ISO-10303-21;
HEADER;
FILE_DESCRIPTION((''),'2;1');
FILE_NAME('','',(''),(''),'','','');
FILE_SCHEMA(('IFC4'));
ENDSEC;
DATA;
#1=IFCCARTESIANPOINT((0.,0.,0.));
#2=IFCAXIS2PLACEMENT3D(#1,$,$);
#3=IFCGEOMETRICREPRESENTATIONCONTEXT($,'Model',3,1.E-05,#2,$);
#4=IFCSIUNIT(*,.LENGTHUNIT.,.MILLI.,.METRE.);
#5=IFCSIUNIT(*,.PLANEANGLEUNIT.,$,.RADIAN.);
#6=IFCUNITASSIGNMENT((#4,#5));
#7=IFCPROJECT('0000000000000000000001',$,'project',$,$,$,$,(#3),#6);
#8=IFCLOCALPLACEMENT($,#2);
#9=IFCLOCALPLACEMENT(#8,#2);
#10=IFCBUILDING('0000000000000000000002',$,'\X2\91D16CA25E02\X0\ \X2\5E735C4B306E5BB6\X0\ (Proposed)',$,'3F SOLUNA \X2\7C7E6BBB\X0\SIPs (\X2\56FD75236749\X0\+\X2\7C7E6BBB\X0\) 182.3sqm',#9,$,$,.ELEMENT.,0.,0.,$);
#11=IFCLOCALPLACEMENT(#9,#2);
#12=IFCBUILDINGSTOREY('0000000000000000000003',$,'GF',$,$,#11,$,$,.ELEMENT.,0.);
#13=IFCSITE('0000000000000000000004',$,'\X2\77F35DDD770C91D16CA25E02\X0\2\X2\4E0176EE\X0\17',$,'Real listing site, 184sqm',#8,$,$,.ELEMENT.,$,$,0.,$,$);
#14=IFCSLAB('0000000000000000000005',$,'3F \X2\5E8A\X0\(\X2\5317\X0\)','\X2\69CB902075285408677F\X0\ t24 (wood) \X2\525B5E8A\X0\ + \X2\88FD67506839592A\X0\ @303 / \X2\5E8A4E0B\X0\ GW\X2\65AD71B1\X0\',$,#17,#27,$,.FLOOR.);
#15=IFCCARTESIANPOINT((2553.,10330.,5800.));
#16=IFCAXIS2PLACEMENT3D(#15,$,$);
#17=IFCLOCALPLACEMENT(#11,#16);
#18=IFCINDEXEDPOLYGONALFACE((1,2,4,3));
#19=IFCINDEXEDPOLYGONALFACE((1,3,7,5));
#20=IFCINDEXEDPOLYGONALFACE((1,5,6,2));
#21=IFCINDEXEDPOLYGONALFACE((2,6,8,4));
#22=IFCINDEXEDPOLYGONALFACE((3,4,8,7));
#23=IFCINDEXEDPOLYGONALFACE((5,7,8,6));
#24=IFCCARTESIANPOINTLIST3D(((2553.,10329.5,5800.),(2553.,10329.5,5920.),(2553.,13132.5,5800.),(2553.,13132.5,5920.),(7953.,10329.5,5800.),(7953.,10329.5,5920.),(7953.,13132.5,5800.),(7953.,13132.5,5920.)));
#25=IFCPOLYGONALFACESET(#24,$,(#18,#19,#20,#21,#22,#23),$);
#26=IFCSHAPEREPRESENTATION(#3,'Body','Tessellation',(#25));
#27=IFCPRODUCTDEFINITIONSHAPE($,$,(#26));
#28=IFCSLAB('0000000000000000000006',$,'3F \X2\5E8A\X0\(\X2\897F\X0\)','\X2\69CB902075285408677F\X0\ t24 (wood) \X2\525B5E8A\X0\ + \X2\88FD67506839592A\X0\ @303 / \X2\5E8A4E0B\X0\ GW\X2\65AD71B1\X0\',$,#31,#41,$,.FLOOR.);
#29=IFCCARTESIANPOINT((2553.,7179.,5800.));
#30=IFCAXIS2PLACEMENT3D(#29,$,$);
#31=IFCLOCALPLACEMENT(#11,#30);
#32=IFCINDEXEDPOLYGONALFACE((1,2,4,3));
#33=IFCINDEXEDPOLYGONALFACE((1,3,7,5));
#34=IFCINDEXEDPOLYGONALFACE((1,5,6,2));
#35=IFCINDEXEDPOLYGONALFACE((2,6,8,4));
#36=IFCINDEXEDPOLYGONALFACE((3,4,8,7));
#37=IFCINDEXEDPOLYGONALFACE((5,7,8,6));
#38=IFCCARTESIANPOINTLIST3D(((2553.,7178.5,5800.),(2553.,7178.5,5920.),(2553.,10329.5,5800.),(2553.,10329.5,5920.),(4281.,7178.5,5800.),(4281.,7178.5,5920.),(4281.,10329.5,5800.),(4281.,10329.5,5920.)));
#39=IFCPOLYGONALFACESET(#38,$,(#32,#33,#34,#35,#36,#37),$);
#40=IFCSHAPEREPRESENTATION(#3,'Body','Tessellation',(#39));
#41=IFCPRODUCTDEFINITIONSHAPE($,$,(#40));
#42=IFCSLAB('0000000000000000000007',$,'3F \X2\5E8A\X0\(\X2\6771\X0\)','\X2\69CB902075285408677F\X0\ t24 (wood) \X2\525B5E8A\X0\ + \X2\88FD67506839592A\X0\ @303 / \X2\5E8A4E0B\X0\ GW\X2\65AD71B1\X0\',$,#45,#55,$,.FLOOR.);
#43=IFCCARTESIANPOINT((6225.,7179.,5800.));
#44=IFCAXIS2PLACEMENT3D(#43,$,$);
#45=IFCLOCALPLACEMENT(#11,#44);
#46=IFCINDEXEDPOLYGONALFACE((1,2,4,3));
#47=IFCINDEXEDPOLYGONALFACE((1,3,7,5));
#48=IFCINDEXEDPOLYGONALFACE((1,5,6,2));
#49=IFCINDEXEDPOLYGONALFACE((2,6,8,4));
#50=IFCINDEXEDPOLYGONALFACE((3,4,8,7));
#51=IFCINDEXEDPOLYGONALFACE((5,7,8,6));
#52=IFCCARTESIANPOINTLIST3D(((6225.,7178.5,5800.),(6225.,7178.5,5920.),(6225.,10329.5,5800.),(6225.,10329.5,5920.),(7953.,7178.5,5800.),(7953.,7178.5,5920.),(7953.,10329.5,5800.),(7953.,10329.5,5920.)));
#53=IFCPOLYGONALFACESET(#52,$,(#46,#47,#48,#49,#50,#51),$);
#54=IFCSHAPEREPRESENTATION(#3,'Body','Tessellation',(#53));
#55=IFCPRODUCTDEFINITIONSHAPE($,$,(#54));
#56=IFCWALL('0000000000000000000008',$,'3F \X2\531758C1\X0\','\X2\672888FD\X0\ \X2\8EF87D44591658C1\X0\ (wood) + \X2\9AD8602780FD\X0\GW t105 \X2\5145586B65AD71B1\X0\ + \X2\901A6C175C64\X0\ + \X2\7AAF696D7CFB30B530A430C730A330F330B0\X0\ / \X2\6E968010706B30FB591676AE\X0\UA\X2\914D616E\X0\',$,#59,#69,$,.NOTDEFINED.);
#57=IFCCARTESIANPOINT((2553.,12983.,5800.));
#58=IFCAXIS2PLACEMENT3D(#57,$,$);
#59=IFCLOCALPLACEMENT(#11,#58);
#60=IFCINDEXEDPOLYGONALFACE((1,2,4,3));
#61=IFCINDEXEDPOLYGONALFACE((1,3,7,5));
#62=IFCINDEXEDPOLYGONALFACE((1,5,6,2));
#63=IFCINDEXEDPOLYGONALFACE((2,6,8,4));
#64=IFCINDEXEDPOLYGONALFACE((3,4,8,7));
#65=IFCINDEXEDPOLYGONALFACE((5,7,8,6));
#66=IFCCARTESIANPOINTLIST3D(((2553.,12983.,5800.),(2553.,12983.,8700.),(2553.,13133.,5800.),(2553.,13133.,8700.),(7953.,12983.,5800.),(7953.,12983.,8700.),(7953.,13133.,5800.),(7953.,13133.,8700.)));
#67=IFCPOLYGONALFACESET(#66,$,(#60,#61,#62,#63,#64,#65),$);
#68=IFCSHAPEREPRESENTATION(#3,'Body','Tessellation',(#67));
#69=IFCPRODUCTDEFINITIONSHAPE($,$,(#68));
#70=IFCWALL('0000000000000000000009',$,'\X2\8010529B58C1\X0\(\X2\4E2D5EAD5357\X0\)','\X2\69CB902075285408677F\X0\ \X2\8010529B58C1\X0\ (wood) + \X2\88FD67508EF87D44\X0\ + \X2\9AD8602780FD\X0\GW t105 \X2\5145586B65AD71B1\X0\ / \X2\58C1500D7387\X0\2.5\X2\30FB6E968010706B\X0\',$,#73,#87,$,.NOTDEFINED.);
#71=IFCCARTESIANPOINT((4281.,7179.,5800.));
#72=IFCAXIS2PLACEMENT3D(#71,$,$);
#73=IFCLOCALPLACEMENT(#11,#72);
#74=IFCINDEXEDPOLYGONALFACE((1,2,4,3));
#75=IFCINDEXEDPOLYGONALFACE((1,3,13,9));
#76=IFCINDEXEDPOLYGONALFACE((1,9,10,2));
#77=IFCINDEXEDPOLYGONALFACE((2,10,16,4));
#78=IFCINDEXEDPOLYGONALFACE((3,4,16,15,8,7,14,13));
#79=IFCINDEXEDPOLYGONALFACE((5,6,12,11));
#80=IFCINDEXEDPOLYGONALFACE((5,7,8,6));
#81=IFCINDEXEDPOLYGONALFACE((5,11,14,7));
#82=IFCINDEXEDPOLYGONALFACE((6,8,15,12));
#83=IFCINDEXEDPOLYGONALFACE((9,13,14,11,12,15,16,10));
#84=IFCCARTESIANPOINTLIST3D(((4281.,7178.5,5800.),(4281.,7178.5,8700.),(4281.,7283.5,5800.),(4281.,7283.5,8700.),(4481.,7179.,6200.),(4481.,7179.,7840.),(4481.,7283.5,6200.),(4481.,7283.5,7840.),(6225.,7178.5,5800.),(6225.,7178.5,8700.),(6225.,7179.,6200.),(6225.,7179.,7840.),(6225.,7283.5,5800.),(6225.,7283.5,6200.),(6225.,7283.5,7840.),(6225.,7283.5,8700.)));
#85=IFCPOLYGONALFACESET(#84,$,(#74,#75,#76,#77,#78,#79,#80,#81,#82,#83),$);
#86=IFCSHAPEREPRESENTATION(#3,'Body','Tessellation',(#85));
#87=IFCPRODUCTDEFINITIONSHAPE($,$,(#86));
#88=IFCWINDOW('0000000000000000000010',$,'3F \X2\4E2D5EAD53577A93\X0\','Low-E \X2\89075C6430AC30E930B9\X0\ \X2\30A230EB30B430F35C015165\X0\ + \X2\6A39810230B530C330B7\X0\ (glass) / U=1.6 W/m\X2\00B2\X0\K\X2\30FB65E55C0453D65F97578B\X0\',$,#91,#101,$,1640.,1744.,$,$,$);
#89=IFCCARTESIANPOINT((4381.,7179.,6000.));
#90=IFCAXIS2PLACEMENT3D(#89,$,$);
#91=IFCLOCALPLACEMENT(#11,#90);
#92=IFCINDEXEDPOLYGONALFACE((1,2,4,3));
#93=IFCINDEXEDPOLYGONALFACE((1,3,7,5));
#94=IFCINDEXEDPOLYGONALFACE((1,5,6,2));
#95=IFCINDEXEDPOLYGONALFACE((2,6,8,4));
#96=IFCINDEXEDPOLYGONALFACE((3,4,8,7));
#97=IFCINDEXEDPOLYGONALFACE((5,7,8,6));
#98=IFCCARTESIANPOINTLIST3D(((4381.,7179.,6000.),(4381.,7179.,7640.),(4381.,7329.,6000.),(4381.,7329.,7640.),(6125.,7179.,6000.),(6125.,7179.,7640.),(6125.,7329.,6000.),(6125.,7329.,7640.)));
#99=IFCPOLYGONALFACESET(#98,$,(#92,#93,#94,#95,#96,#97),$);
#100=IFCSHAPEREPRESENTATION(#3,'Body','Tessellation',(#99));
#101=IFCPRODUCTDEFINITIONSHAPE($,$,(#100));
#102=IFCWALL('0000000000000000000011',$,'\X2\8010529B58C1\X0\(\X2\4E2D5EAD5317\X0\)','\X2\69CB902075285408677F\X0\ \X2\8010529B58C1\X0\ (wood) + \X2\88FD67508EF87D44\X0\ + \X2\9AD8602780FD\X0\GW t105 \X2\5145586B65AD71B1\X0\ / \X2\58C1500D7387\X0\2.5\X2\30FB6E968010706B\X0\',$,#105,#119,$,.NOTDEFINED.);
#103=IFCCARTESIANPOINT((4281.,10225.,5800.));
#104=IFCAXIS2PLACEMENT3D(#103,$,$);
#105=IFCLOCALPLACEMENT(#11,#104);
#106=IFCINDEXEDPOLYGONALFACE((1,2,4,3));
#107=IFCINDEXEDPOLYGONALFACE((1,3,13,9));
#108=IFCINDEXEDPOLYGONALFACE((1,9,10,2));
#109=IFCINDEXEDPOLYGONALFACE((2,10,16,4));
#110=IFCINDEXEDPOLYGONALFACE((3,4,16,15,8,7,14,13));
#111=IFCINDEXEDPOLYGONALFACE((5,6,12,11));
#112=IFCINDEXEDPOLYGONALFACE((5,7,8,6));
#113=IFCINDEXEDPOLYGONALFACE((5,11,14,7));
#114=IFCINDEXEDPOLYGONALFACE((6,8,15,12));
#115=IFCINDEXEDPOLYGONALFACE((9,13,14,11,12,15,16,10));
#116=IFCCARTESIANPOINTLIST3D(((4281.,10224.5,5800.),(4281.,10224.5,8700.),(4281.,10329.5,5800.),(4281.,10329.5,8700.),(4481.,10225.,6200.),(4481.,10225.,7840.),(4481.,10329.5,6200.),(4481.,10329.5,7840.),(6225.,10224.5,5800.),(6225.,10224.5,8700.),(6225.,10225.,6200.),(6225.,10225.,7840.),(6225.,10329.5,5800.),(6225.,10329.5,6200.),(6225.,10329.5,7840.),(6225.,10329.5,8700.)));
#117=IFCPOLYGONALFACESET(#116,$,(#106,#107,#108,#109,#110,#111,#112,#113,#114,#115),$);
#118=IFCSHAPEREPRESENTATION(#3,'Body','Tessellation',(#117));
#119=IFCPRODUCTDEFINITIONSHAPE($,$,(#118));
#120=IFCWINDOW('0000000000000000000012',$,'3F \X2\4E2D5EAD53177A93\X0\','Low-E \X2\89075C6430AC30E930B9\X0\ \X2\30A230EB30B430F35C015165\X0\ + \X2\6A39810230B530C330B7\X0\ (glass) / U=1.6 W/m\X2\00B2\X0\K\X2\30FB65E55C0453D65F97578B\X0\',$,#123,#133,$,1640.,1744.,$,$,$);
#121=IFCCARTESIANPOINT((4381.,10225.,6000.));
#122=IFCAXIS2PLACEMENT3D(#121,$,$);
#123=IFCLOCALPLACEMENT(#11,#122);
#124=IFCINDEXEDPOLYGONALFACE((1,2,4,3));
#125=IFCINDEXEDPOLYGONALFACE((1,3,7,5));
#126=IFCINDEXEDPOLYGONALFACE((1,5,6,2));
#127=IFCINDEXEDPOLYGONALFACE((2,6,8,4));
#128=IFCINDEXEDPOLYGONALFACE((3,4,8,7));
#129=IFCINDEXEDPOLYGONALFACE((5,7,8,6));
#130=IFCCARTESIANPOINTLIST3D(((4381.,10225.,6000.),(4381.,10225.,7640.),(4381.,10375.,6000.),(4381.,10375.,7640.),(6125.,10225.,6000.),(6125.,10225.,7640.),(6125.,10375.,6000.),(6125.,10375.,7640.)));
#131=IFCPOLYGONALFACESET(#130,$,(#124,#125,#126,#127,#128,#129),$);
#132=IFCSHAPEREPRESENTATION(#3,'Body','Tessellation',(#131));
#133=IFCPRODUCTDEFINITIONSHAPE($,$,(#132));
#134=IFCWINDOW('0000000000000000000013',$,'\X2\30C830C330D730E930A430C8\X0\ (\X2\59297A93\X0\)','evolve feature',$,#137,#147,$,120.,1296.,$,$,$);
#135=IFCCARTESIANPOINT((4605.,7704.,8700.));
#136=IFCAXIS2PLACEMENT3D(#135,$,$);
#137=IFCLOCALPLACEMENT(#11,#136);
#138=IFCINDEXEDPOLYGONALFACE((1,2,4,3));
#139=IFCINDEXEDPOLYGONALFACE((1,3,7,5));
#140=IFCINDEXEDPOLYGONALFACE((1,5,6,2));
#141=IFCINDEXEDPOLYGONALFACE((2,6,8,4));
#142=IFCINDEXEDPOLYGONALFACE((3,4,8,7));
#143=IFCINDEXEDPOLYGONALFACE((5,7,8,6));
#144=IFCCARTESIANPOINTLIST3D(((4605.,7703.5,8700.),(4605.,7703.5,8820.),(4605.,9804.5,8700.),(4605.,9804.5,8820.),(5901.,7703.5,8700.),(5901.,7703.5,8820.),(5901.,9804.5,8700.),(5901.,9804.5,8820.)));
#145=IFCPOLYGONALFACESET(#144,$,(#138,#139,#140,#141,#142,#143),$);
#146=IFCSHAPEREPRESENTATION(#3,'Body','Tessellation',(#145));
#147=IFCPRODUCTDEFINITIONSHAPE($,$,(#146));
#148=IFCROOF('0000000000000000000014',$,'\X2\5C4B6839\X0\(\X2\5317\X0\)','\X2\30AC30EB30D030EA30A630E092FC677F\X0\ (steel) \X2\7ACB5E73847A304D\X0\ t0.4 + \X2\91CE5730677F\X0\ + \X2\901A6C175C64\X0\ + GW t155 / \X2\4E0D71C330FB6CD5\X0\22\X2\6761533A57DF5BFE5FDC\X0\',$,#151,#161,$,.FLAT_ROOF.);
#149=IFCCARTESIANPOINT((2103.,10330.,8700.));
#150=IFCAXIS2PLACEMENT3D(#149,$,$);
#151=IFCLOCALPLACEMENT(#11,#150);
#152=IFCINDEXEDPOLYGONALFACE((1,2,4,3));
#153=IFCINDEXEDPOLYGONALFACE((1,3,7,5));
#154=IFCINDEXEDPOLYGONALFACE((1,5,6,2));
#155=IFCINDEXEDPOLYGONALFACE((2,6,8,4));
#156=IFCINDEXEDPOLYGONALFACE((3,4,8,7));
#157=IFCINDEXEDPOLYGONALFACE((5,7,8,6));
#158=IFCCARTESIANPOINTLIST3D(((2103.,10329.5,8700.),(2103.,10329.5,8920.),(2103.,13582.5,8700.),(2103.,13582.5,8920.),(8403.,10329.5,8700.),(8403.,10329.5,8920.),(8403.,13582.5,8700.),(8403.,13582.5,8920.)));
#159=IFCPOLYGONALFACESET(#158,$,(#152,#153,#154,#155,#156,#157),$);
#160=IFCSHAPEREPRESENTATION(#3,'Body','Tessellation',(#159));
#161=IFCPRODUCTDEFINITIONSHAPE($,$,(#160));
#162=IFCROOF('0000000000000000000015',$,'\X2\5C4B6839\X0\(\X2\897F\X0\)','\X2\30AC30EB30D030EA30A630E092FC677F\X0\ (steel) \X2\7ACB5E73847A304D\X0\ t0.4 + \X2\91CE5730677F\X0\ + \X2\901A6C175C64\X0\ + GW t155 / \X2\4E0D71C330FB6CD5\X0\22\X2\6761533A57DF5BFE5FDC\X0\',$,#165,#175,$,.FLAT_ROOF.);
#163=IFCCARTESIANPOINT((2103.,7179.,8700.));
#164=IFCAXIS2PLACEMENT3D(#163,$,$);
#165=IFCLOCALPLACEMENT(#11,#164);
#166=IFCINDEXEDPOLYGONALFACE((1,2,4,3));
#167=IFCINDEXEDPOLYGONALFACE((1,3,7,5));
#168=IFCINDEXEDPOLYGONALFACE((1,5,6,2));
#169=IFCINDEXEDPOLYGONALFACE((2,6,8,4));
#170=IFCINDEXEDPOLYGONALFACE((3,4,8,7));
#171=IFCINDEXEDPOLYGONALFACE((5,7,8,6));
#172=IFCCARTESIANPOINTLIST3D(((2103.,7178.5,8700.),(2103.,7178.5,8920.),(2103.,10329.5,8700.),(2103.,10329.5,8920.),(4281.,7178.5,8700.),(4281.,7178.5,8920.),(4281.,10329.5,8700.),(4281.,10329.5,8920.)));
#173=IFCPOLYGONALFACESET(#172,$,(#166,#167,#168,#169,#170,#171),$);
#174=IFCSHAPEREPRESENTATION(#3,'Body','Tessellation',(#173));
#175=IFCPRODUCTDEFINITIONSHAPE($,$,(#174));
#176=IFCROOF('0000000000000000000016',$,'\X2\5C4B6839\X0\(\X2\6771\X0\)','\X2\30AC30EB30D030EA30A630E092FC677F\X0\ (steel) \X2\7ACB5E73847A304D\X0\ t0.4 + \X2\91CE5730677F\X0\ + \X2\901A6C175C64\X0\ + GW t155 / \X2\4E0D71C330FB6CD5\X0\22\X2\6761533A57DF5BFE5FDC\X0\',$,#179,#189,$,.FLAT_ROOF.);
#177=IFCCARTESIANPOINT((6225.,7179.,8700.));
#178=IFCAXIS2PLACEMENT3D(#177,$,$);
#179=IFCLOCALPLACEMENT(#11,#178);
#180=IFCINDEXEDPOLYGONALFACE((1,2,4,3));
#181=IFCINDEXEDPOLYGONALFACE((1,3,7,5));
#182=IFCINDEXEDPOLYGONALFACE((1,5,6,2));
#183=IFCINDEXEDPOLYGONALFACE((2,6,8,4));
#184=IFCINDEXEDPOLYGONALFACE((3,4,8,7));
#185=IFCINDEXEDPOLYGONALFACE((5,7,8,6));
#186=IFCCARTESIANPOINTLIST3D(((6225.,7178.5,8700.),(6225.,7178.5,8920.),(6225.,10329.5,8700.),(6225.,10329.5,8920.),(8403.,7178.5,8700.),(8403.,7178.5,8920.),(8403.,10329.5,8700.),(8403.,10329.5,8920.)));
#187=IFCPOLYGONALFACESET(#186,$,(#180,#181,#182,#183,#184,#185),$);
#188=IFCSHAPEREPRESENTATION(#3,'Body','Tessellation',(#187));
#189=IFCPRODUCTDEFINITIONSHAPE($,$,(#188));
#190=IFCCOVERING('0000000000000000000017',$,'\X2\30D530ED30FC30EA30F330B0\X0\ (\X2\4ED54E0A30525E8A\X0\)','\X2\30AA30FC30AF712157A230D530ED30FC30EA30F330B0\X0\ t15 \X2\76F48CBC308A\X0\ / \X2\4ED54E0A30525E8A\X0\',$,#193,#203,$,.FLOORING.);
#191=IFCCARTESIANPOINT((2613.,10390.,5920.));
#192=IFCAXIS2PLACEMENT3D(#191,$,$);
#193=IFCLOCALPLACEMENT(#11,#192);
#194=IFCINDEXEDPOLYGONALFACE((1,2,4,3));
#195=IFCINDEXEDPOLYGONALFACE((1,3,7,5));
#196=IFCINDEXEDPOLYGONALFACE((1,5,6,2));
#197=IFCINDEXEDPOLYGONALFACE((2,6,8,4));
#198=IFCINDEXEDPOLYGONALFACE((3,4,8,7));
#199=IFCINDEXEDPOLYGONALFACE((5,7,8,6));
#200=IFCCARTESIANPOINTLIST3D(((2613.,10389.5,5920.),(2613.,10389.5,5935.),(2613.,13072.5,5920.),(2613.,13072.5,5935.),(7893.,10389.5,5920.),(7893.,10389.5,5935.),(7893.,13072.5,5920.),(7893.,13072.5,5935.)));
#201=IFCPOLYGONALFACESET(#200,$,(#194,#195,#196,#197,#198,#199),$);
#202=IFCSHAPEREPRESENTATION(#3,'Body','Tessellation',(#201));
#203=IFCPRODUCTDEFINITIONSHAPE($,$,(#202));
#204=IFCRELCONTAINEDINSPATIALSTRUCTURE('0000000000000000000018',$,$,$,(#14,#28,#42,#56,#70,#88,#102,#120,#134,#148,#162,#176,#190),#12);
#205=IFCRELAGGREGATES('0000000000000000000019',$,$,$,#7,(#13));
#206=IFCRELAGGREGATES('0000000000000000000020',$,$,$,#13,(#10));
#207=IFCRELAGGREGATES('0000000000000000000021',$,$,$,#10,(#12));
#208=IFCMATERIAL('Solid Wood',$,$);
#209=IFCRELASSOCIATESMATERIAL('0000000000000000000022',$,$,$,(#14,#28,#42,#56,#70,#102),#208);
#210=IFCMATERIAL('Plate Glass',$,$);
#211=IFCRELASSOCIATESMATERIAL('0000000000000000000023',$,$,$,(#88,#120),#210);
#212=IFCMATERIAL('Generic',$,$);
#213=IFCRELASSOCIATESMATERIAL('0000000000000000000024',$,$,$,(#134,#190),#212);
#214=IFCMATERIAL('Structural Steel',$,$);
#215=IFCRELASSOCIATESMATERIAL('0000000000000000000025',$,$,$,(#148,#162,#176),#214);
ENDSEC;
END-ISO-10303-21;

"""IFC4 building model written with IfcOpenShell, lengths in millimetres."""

from ifc_helpers import new_model, si_unit, frame, frame_2d, origin, place, context, project, spatial, rectangle, extrude, material, element, fill, save


model = new_model("IFC4")

# Units and contexts
model_context = context("Model", 3, precision=1e-05, world=origin())
ifc_project = project(units=[si_unit("LENGTHUNIT", "METRE", prefix="MILLI"), si_unit("PLANEANGLEUNIT", "RADIAN")], contexts=[model_context])

# Site, building, storey
site_placement = place(None, origin())
site = spatial("IfcSite", under=ifc_project, at=site_placement, Name="石川県金沢市2丁目17", ObjectType="Real listing site, 184sqm", CompositionType="ELEMENT", RefElevation=0.0)
building_placement = place(site_placement, origin())
building = spatial("IfcBuilding", under=site, at=building_placement, Name="金沢市 平屋の家 (Proposed)", ObjectType="3F SOLUNA 籾殻SIPs (国産杉+籾殻) 182.3sqm", CompositionType="ELEMENT", ElevationOfRefHeight=0.0, ElevationOfTerrain=0.0)
storey_placement = place(building_placement, origin())
storey = spatial("IfcBuildingStorey", under=building, at=storey_placement, Name="GF", CompositionType="ELEMENT", Elevation=0.0)

# Slabs
ifc_material_1 = material(Name="Solid Wood")
slab_1_placement = place(storey_placement, frame((2553.0, 10330.0, 5800.0)))
element("IfcSlab", 1, at=slab_1_placement, inside=storey, material=ifc_material_1, Name="3F 床(北)", Description="構造用合板 t24 (wood) 剛床 + 製材根太 @303 / 床下 GW断熱", PredefinedType="FLOOR", context=model_context, shape_type="SweptSolid", body=[
    extrude(rectangle(XDim=5400.0, YDim=2803.0, at=frame_2d((2700.0, 1401.0))), frame((2553.0, 10330.0, 5800.0)), (0.0, 0.0, 1.0), 120.0),
])
slab_2_placement = place(storey_placement, frame((2553.0, 7179.0, 5800.0)))
element("IfcSlab", 2, at=slab_2_placement, inside=storey, material=ifc_material_1, Name="3F 床(西)", Description="構造用合板 t24 (wood) 剛床 + 製材根太 @303 / 床下 GW断熱", PredefinedType="FLOOR", context=model_context, shape_type="SweptSolid", body=[
    extrude(rectangle(XDim=1728.0, YDim=3151.0, at=frame_2d((864.0, 1575.0))), frame((2553.0, 7179.0, 5800.0)), (0.0, 0.0, 1.0), 120.0),
])
slab_3_placement = place(storey_placement, frame((6225.0, 7179.0, 5800.0)))
element("IfcSlab", 3, at=slab_3_placement, inside=storey, material=ifc_material_1, Name="3F 床(東)", Description="構造用合板 t24 (wood) 剛床 + 製材根太 @303 / 床下 GW断熱", PredefinedType="FLOOR", context=model_context, shape_type="SweptSolid", body=[
    extrude(rectangle(XDim=1728.0, YDim=3151.0, at=frame_2d((864.0, 1575.0))), frame((6225.0, 7179.0, 5800.0)), (0.0, 0.0, 1.0), 120.0),
])

# Wall
wall_1_placement = place(storey_placement, frame((2553.0, 12983.0, 5800.0)))
element("IfcWall", 4, at=wall_1_placement, inside=storey, material=ifc_material_1, Name="3F 北壁", Description="木製 軸組外壁 (wood) + 高性能GW t105 充填断熱 + 通気層 + 窯業系サイディング / 準耐火・外皮UA配慮", PredefinedType="NOTDEFINED", context=model_context, shape_type="SweptSolid", body=[
    extrude(rectangle(XDim=5400.0, YDim=150.0, at=frame_2d((2700.0, 75.0))), frame((2553.0, 12983.0, 5800.0)), (0.0, 0.0, 1.0), 2900.0),
])

# Walls, openings, windows
wall_2_placement = place(storey_placement, frame((4281.0, 7179.0, 5800.0)))
wall_2 = element("IfcWall", 5, at=wall_2_placement, inside=storey, material=ifc_material_1, Name="耐力壁(中庭南)", Description="構造用合板 耐力壁 (wood) + 製材軸組 + 高性能GW t105 充填断熱 / 壁倍率2.5・準耐火", PredefinedType="NOTDEFINED", context=model_context, shape_type="SweptSolid", body=[
    extrude(rectangle(XDim=1944.0, YDim=105.0, at=frame_2d((972.0, 52.0))), frame((4281.0, 7179.0, 5800.0)), (0.0, 0.0, 1.0), 2900.0),
])
opening_1_placement = place(storey_placement, frame((4381.0, 7179.0, 6000.0)))
opening_1 = element("IfcOpeningElement", 6, at=opening_1_placement, cuts=wall_2, PredefinedType="NOTDEFINED", context=model_context, shape_type="SweptSolid", body=[
    extrude(rectangle(XDim=1744.0, YDim=150.0, at=frame_2d((872.0, 75.0))), frame((4381.0, 7179.0, 6000.0)), (0.0, 0.0, 1.0), 1640.0),
])
ifc_material_2 = material(Name="Plate Glass")
window_1_placement = place(storey_placement, frame((4381.0, 7179.0, 6000.0)))
window_1 = element("IfcWindow", 7, at=window_1_placement, inside=storey, material=ifc_material_2, Name="3F 中庭南窓", Description="Low-E 複層ガラス アルゴン封入 + 樹脂サッシ (glass) / U=1.6 W/m²K・日射取得型", OverallHeight=1640.0, OverallWidth=1744.0, context=model_context, shape_type="SweptSolid", body=[
    extrude(rectangle(XDim=1744.0, YDim=150.0, at=frame_2d((872.0, 75.0))), frame((4381.0, 7179.0, 6000.0)), (0.0, 0.0, 1.0), 1640.0),
])
fill(opening_1, window_1)
wall_3_placement = place(storey_placement, frame((4281.0, 10225.0, 5800.0)))
wall_3 = element("IfcWall", 8, at=wall_3_placement, inside=storey, material=ifc_material_1, Name="耐力壁(中庭北)", Description="構造用合板 耐力壁 (wood) + 製材軸組 + 高性能GW t105 充填断熱 / 壁倍率2.5・準耐火", PredefinedType="NOTDEFINED", context=model_context, shape_type="SweptSolid", body=[
    extrude(rectangle(XDim=1944.0, YDim=105.0, at=frame_2d((972.0, 52.0))), frame((4281.0, 10225.0, 5800.0)), (0.0, 0.0, 1.0), 2900.0),
])
opening_2_placement = place(storey_placement, frame((4381.0, 10225.0, 6000.0)))
opening_2 = element("IfcOpeningElement", 9, at=opening_2_placement, cuts=wall_3, PredefinedType="NOTDEFINED", context=model_context, shape_type="SweptSolid", body=[
    extrude(rectangle(XDim=1744.0, YDim=150.0, at=frame_2d((872.0, 75.0))), frame((4381.0, 10225.0, 6000.0)), (0.0, 0.0, 1.0), 1640.0),
])
window_2_placement = place(storey_placement, frame((4381.0, 10225.0, 6000.0)))
window_2 = element("IfcWindow", 10, at=window_2_placement, inside=storey, material=ifc_material_2, Name="3F 中庭北窓", Description="Low-E 複層ガラス アルゴン封入 + 樹脂サッシ (glass) / U=1.6 W/m²K・日射取得型", OverallHeight=1640.0, OverallWidth=1744.0, context=model_context, shape_type="SweptSolid", body=[
    extrude(rectangle(XDim=1744.0, YDim=150.0, at=frame_2d((872.0, 75.0))), frame((4381.0, 10225.0, 6000.0)), (0.0, 0.0, 1.0), 1640.0),
])
fill(opening_2, window_2)

# Window
ifc_material_3 = material(Name="Generic")
window_3_placement = place(storey_placement, frame((4605.0, 7704.0, 8700.0)))
element("IfcWindow", 11, at=window_3_placement, inside=storey, material=ifc_material_3, Name="トップライト (天窓)", Description="evolve feature", OverallHeight=120.0, OverallWidth=1296.0, context=model_context, shape_type="SweptSolid", body=[
    extrude(rectangle(XDim=1296.0, YDim=2101.0, at=frame_2d((648.0, 1050.0))), frame((4605.0, 7704.0, 8700.0)), (0.0, 0.0, 1.0), 120.0),
])

# Roofs
ifc_material_4 = material(Name="Structural Steel")
for number, where, name in (
    (12, (2103.0, 10330.0, 8700.0), "屋根(北)"),
):
    element("IfcRoof", number, at=place(storey_placement, frame(where)), inside=storey, material=ifc_material_4, Name=name, Description="ガルバリウム鋼板 (steel) 立平葺き t0.4 + 野地板 + 通気層 + GW t155 / 不燃・法22条区域対応", PredefinedType="FLAT_ROOF", context=model_context, shape_type="SweptSolid", body=[
        extrude(rectangle(XDim=6300.0, YDim=3253.0, at=frame_2d((3150.0, 1626.0))), frame((2103.0, 10330.0, 8700.0)), (0.0, 0.0, 1.0), 220.0),
    ])
roof_1_placement = place(storey_placement, frame((2103.0, 7179.0, 8700.0)))
element("IfcRoof", 13, at=roof_1_placement, inside=storey, material=ifc_material_4, Name="屋根(西)", Description="ガルバリウム鋼板 (steel) 立平葺き t0.4 + 野地板 + 通気層 + GW t155 / 不燃・法22条区域対応", PredefinedType="FLAT_ROOF", context=model_context, shape_type="SweptSolid", body=[
    extrude(rectangle(XDim=2178.0, YDim=3151.0, at=frame_2d((1089.0, 1575.0))), frame((2103.0, 7179.0, 8700.0)), (0.0, 0.0, 1.0), 220.0),
])
roof_2_placement = place(storey_placement, frame((6225.0, 7179.0, 8700.0)))
element("IfcRoof", 14, at=roof_2_placement, inside=storey, material=ifc_material_4, Name="屋根(東)", Description="ガルバリウム鋼板 (steel) 立平葺き t0.4 + 野地板 + 通気層 + GW t155 / 不燃・法22条区域対応", PredefinedType="FLAT_ROOF", context=model_context, shape_type="SweptSolid", body=[
    extrude(rectangle(XDim=2178.0, YDim=3151.0, at=frame_2d((1089.0, 1575.0))), frame((6225.0, 7179.0, 8700.0)), (0.0, 0.0, 1.0), 220.0),
])

# Covering
covering_1_placement = place(storey_placement, frame((2613.0, 10390.0, 5920.0)))
element("IfcCovering", 15, at=covering_1_placement, inside=storey, material=ifc_material_3, Name="フローリング (仕上げ床)", Description="オーク無垢フローリング t15 直貼り / 仕上げ床", PredefinedType="FLOORING", context=model_context, shape_type="SweptSolid", body=[
    extrude(rectangle(XDim=5280.0, YDim=2683.0, at=frame_2d((2640.0, 1341.0))), frame((2613.0, 10390.0, 5920.0)), (0.0, 0.0, 1.0), 15.0),
])

save(model, "model.ifc")
